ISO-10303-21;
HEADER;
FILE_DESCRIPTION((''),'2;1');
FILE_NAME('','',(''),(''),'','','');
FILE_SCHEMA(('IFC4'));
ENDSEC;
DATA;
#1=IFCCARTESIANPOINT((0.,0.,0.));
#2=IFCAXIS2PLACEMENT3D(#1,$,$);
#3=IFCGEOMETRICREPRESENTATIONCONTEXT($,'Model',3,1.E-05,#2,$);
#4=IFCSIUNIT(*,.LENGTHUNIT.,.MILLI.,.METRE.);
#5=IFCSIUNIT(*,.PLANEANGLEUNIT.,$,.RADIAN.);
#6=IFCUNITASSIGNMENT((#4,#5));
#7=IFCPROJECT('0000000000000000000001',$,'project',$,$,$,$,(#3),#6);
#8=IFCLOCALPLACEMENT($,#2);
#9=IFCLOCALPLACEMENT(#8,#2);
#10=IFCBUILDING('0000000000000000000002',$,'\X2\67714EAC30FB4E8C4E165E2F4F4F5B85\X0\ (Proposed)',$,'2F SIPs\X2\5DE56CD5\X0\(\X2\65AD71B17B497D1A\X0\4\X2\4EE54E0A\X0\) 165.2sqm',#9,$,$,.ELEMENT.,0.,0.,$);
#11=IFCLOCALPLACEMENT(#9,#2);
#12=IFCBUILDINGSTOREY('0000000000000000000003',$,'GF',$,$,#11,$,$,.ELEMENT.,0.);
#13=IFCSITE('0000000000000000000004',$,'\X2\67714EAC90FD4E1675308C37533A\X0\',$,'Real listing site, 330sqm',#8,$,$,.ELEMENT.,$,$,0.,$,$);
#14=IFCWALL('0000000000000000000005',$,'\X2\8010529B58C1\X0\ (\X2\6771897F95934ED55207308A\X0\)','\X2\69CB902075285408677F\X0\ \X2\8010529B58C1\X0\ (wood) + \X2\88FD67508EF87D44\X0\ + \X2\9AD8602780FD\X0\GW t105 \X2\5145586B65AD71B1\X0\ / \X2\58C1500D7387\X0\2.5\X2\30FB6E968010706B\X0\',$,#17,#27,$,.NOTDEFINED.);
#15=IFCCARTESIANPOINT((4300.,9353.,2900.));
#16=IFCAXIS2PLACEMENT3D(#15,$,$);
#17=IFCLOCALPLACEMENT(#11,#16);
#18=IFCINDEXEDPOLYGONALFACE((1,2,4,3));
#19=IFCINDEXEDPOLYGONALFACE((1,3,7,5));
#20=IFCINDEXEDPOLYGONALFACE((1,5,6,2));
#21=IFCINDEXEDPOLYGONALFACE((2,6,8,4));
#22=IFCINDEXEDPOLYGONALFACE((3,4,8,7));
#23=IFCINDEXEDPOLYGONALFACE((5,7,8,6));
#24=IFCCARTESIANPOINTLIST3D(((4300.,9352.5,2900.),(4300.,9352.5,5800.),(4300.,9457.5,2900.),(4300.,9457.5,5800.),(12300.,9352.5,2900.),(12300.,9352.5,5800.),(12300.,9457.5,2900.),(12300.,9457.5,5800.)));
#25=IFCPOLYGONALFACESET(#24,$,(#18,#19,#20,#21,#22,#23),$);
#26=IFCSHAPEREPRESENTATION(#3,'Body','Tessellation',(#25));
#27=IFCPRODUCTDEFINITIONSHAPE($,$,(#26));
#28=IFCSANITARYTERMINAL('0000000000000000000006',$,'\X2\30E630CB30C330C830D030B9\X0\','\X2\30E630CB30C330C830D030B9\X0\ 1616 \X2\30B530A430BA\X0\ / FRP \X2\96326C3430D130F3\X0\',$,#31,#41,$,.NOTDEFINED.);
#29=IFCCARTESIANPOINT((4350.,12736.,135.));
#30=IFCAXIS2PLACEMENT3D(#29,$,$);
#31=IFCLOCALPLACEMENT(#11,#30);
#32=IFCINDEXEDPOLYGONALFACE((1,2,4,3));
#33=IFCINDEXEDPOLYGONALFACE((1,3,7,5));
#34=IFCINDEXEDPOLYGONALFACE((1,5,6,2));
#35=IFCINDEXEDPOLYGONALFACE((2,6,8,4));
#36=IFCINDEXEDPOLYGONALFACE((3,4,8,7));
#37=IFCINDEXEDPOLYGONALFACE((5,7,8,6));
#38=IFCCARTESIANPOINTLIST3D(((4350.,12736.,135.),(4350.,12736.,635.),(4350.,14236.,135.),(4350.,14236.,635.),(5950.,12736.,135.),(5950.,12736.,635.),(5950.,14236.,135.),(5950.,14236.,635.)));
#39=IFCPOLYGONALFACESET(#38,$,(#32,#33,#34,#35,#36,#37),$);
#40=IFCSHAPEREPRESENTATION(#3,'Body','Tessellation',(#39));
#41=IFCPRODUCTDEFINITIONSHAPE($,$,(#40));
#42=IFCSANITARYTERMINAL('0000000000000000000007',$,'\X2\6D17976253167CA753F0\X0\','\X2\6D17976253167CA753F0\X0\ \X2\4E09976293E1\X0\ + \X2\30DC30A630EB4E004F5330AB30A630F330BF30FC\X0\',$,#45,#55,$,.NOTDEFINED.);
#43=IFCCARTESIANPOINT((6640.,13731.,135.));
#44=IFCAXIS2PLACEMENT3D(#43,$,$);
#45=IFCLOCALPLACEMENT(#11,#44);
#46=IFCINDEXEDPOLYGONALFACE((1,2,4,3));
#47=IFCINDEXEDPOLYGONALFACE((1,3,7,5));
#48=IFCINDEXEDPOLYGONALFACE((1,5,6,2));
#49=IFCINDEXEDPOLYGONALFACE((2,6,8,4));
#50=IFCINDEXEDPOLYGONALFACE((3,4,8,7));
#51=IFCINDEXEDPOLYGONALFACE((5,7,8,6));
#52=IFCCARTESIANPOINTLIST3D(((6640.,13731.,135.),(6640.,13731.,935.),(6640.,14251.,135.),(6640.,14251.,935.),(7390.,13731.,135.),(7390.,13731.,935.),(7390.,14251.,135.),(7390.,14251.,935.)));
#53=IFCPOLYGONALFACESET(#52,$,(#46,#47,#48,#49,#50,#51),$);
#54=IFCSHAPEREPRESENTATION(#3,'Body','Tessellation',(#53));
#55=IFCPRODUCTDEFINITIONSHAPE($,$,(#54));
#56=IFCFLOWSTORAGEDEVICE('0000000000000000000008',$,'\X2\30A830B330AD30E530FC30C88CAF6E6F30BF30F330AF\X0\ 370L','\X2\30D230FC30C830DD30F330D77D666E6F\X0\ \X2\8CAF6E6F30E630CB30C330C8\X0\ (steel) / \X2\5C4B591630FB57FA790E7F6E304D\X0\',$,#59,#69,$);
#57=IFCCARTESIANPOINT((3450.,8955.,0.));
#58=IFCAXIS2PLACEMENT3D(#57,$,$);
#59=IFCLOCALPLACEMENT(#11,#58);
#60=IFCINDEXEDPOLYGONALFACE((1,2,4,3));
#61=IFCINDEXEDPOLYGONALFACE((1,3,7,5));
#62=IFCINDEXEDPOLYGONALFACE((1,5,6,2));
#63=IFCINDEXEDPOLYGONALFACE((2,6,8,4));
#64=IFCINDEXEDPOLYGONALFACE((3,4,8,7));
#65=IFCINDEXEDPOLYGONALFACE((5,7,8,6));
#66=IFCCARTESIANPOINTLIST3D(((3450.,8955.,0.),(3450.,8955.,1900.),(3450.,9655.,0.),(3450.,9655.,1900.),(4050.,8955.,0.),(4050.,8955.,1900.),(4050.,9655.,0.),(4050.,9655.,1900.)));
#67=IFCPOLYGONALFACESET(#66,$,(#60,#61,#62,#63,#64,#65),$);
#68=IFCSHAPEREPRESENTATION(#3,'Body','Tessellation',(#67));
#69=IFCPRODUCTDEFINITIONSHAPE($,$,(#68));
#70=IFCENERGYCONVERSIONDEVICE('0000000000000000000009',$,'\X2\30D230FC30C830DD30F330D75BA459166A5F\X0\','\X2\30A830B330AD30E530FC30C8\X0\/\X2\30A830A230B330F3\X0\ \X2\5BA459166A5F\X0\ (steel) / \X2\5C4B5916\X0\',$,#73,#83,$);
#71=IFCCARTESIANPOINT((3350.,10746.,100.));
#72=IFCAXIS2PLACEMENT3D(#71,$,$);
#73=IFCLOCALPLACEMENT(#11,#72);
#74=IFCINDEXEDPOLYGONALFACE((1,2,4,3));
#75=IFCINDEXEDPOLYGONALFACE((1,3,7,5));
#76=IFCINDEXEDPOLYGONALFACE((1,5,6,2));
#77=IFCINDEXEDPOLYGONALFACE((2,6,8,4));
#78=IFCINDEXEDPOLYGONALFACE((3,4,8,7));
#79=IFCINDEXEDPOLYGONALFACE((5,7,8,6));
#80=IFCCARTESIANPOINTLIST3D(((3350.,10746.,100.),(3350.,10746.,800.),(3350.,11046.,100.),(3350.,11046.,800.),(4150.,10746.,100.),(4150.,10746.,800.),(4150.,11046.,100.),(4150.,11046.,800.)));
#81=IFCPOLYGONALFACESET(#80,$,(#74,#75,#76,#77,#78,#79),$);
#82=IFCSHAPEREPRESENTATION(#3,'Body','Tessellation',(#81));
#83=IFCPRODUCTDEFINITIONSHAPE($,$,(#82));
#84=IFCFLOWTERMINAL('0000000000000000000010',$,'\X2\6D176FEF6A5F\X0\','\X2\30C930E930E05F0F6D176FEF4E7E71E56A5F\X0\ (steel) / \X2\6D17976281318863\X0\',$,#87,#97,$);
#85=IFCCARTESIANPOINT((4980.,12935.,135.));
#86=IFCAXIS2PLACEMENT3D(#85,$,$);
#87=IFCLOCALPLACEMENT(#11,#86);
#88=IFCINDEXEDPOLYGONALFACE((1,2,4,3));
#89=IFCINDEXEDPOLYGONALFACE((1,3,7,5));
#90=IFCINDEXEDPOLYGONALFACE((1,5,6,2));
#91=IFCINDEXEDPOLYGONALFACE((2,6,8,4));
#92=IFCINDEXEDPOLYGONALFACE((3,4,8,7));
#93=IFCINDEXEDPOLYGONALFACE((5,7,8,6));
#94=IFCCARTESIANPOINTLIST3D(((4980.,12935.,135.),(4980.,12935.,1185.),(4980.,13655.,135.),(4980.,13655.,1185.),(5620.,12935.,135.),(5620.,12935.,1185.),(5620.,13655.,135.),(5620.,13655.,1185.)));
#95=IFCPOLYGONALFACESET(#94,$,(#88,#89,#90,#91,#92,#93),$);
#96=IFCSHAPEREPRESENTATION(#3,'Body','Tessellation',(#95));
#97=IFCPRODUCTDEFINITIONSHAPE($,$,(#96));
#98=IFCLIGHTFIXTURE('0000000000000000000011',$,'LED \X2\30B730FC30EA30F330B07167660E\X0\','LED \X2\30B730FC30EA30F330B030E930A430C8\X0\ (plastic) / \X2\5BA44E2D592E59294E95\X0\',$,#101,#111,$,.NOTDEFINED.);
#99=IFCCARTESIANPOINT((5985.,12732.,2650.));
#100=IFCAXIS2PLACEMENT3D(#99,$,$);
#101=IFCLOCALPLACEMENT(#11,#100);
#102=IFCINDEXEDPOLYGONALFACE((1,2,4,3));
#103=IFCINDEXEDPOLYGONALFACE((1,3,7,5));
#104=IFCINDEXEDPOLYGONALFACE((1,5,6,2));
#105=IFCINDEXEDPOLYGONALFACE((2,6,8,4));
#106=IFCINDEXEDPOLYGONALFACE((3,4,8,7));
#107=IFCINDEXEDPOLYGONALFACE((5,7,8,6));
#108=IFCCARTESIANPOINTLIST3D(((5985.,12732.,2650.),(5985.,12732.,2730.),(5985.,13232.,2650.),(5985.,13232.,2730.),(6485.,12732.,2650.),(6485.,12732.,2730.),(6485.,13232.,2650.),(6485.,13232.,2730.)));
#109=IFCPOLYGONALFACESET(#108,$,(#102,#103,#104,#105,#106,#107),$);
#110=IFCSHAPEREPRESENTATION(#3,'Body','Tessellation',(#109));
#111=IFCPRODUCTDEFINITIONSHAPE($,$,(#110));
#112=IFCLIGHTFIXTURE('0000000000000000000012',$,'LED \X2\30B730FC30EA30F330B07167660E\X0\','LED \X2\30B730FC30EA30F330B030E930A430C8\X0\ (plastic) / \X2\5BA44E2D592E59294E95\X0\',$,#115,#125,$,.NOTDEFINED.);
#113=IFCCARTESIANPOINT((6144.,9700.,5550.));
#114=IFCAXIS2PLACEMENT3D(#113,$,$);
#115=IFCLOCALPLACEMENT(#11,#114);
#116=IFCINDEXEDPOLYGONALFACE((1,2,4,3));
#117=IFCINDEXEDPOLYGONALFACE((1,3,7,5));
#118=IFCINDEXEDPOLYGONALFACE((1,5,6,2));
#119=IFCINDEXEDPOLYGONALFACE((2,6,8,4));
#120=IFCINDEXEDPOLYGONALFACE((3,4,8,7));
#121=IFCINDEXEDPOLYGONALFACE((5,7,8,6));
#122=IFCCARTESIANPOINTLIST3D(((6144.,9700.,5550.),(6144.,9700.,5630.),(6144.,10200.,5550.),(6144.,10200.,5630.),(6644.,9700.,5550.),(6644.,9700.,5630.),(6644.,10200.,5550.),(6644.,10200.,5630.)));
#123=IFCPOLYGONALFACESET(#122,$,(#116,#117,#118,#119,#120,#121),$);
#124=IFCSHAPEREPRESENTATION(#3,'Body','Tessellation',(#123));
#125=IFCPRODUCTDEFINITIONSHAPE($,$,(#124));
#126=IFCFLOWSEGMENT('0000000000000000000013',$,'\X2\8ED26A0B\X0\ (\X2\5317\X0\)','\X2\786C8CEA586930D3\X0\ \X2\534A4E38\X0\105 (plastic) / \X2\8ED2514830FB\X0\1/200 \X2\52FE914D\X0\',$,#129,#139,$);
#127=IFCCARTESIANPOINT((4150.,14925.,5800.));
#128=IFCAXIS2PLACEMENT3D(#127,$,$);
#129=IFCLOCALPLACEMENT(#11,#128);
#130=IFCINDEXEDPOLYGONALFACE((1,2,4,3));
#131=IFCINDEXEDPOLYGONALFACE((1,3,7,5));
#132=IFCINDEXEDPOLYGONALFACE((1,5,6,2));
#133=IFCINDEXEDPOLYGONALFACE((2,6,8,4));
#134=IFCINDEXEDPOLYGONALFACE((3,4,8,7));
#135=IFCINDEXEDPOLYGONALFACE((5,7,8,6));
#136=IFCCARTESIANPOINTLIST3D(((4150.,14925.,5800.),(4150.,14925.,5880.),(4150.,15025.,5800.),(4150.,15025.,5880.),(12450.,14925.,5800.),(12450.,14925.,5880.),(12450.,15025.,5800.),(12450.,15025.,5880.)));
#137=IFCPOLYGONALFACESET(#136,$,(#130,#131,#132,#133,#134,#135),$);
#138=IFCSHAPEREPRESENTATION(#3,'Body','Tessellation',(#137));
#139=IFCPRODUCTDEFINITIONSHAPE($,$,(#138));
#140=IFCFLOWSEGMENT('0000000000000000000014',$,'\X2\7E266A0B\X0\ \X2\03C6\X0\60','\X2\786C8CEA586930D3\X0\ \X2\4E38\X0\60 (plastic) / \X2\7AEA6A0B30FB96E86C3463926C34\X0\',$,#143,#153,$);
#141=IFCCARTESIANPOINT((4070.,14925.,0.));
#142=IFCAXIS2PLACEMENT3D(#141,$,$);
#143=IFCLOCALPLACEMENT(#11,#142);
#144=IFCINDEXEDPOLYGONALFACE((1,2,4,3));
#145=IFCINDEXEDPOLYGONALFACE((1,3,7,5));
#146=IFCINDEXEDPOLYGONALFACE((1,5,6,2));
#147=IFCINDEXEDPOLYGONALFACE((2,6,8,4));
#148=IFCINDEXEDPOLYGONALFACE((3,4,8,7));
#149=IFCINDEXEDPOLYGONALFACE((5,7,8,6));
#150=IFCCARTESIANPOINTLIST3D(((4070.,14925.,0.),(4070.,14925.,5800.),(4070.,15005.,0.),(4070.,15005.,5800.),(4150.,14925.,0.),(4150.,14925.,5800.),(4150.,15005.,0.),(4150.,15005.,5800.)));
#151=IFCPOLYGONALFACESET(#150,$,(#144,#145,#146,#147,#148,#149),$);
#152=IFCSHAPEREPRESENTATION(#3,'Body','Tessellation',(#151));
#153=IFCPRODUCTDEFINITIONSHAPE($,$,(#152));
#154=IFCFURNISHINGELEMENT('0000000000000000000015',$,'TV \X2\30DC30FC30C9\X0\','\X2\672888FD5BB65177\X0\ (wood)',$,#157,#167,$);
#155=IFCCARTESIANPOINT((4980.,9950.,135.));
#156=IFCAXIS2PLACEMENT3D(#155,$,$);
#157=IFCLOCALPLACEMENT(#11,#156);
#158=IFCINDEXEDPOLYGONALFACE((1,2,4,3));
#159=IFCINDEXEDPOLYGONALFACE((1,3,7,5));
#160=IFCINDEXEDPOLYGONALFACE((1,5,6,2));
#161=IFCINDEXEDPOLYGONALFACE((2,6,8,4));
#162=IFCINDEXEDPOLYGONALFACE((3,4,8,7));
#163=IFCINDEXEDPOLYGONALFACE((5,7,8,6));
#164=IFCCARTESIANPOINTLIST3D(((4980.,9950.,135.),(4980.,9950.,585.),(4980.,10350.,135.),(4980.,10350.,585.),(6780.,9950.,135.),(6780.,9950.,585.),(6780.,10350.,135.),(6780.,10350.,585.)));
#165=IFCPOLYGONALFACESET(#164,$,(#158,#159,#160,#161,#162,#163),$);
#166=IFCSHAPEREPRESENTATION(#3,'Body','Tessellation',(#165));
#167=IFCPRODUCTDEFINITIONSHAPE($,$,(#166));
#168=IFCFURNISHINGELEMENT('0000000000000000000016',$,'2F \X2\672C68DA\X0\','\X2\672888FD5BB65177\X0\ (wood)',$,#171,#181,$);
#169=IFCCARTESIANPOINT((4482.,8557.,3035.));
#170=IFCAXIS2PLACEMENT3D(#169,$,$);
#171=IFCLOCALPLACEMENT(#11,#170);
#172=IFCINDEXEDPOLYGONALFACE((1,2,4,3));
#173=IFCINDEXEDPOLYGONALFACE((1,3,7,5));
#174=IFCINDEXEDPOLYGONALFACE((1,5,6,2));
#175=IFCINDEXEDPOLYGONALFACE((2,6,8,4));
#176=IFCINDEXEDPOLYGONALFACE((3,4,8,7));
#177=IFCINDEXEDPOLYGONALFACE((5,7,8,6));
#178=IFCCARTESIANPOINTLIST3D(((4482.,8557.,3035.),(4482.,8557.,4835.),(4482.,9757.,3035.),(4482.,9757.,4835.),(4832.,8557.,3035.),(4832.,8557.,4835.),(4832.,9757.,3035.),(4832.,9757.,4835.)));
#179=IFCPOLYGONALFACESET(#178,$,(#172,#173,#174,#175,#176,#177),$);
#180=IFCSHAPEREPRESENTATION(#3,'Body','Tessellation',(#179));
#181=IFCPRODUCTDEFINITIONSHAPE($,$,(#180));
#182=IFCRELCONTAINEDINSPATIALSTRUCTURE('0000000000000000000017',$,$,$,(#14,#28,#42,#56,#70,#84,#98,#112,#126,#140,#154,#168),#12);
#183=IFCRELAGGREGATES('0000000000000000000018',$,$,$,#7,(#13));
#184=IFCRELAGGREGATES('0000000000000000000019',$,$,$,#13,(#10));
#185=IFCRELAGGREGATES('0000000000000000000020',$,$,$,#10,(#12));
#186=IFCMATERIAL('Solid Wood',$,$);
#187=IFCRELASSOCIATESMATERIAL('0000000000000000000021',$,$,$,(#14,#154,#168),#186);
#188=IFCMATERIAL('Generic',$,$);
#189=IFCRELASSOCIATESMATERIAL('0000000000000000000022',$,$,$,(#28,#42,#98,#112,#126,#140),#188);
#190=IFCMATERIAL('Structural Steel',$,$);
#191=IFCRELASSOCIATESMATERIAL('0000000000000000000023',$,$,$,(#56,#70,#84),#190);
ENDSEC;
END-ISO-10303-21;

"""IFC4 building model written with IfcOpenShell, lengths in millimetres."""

from ifc_helpers import new_model, si_unit, frame, frame_2d, origin, place, context, project, spatial, rectangle, extrude, material, element, save


model = new_model("IFC4")

# Units and contexts
model_context = context("Model", 3, precision=1e-05, world=origin())
ifc_project = project(units=[si_unit("LENGTHUNIT", "METRE", prefix="MILLI"), si_unit("PLANEANGLEUNIT", "RADIAN")], contexts=[model_context])

# Site, building, storey
site_placement = place(None, origin())
site = spatial("IfcSite", under=ifc_project, at=site_placement, Name="東京都世田谷区", ObjectType="Real listing site, 330sqm", CompositionType="ELEMENT", RefElevation=0.0)
building_placement = place(site_placement, origin())
building = spatial("IfcBuilding", under=site, at=building_placement, Name="東京・二世帯住宅 (Proposed)", ObjectType="2F SIPs工法(断熱等級4以上) 165.2sqm", CompositionType="ELEMENT", ElevationOfRefHeight=0.0, ElevationOfTerrain=0.0)
storey_placement = place(building_placement, origin())
storey = spatial("IfcBuildingStorey", under=building, at=storey_placement, Name="GF", CompositionType="ELEMENT", Elevation=0.0)

# Shared definitions
ifc_material_1 = material(Name="Solid Wood")

# Wall
wall_1_placement = place(storey_placement, frame((4300.0, 9353.0, 2900.0)))
element("IfcWall", 1, at=wall_1_placement, inside=storey, material=ifc_material_1, Name="耐力壁 (東西間仕切り)", Description="構造用合板 耐力壁 (wood) + 製材軸組 + 高性能GW t105 充填断熱 / 壁倍率2.5・準耐火", PredefinedType="NOTDEFINED", context=model_context, shape_type="SweptSolid", body=[
    extrude(rectangle(XDim=8000.0, YDim=105.0, at=frame_2d((4000.0, 52.0))), frame((4300.0, 9353.0, 2900.0)), (0.0, 0.0, 1.0), 2900.0),
])

# Sanitary terminals
ifc_material_2 = material(Name="Generic")
sanitary_terminal_1_placement = place(storey_placement, frame((4350.0, 12736.0, 135.0)))
element("IfcSanitaryTerminal", 2, at=sanitary_terminal_1_placement, inside=storey, material=ifc_material_2, Name="ユニットバス", Description="ユニットバス 1616 サイズ / FRP 防水パン", PredefinedType="NOTDEFINED", context=model_context, shape_type="SweptSolid", body=[
    extrude(rectangle(XDim=1600.0, YDim=1500.0, at=frame_2d((800.0, 750.0))), frame((4350.0, 12736.0, 135.0)), (0.0, 0.0, 1.0), 500.0),
])
sanitary_terminal_2_placement = place(storey_placement, frame((6640.0, 13731.0, 135.0)))
element("IfcSanitaryTerminal", 3, at=sanitary_terminal_2_placement, inside=storey, material=ifc_material_2, Name="洗面化粧台", Description="洗面化粧台 三面鏡 + ボウル一体カウンター", PredefinedType="NOTDEFINED", context=model_context, shape_type="SweptSolid", body=[
    extrude(rectangle(XDim=750.0, YDim=520.0, at=frame_2d((375.0, 260.0))), frame((6640.0, 13731.0, 135.0)), (0.0, 0.0, 1.0), 800.0),
])

# Flow storage device
ifc_material_3 = material(Name="Structural Steel")
flow_storage_device_placement = place(storey_placement, frame((3450.0, 8955.0, 0.0)))
element("IfcFlowStorageDevice", 4, at=flow_storage_device_placement, inside=storey, material=ifc_material_3, Name="エコキュート貯湯タンク 370L", Description="ヒートポンプ給湯 貯湯ユニット (steel) / 屋外・基礎置き", context=model_context, shape_type="SweptSolid", body=[
    extrude(rectangle(XDim=600.0, YDim=700.0, at=frame_2d((300.0, 350.0))), frame((3450.0, 8955.0, 0.0)), (0.0, 0.0, 1.0), 1900.0),
])

# Energy conversion device
energy_conversion_device_placement = place(storey_placement, frame((3350.0, 10746.0, 100.0)))
element("IfcEnergyConversionDevice", 5, at=energy_conversion_device_placement, inside=storey, material=ifc_material_3, Name="ヒートポンプ室外機", Description="エコキュート/エアコン 室外機 (steel) / 屋外", context=model_context, shape_type="SweptSolid", body=[
    extrude(rectangle(XDim=800.0, YDim=300.0, at=frame_2d((400.0, 150.0))), frame((3350.0, 10746.0, 100.0)), (0.0, 0.0, 1.0), 700.0),
])

# Flow terminal
flow_terminal_placement = place(storey_placement, frame((4980.0, 12935.0, 135.0)))
element("IfcFlowTerminal", 6, at=flow_terminal_placement, inside=storey, material=ifc_material_3, Name="洗濯機", Description="ドラム式洗濯乾燥機 (steel) / 洗面脱衣", context=model_context, shape_type="SweptSolid", body=[
    extrude(rectangle(XDim=640.0, YDim=720.0, at=frame_2d((320.0, 360.0))), frame((4980.0, 12935.0, 135.0)), (0.0, 0.0, 1.0), 1050.0),
])

# Light fixtures
light_fixture_1_placement = place(storey_placement, frame((5985.0, 12732.0, 2650.0)))
element("IfcLightFixture", 7, at=light_fixture_1_placement, inside=storey, material=ifc_material_2, Name="LED シーリング照明", Description="LED シーリングライト (plastic) / 室中央天井", PredefinedType="NOTDEFINED", context=model_context, shape_type="SweptSolid", body=[
    extrude(rectangle(XDim=500.0, YDim=500.0, at=frame_2d((250.0, 250.0))), frame((5985.0, 12732.0, 2650.0)), (0.0, 0.0, 1.0), 80.0),
])
light_fixture_2_placement = place(storey_placement, frame((6144.0, 9700.0, 5550.0)))
element("IfcLightFixture", 8, at=light_fixture_2_placement, inside=storey, material=ifc_material_2, Name="LED シーリング照明", Description="LED シーリングライト (plastic) / 室中央天井", PredefinedType="NOTDEFINED", context=model_context, shape_type="SweptSolid", body=[
    extrude(rectangle(XDim=500.0, YDim=500.0, at=frame_2d((250.0, 250.0))), frame((6144.0, 9700.0, 5550.0)), (0.0, 0.0, 1.0), 80.0),
])

# Flow segments
flow_segment_1_placement = place(storey_placement, frame((4150.0, 14925.0, 5800.0)))
element("IfcFlowSegment", 9, at=flow_segment_1_placement, inside=storey, material=ifc_material_2, Name="軒樋 (北)", Description="硬質塩ビ 半丸105 (plastic) / 軒先・1/200 勾配", context=model_context, shape_type="SweptSolid", body=[
    extrude(rectangle(XDim=8300.0, YDim=100.0, at=frame_2d((4150.0, 50.0))), frame((4150.0, 14925.0, 5800.0)), (0.0, 0.0, 1.0), 80.0),
])
flow_segment_2_placement = place(storey_placement, frame((4070.0, 14925.0, 0.0)))
element("IfcFlowSegment", 10, at=flow_segment_2_placement, inside=storey, material=ifc_material_2, Name="縦樋 φ60", Description="硬質塩ビ 丸60 (plastic) / 竪樋・雨水排水", context=model_context, shape_type="SweptSolid", body=[
    extrude(rectangle(XDim=80.0, YDim=80.0, at=frame_2d((40.0, 40.0))), frame((4070.0, 14925.0, 0.0)), (0.0, 0.0, 1.0), 5800.0),
])

# Furnishing elements
furnishing_1_placement = place(storey_placement, frame((4980.0, 9950.0, 135.0)))
element("IfcFurnishingElement", 11, at=furnishing_1_placement, inside=storey, material=ifc_material_1, Name="TV ボード", Description="木製家具 (wood)", context=model_context, shape_type="SweptSolid", body=[
    extrude(rectangle(XDim=1800.0, YDim=400.0, at=frame_2d((900.0, 200.0))), frame((4980.0, 9950.0, 135.0)), (0.0, 0.0, 1.0), 450.0),
])
furnishing_2_placement = place(storey_placement, frame((4482.0, 8557.0, 3035.0)))
element("IfcFurnishingElement", 12, at=furnishing_2_placement, inside=storey, material=ifc_material_1, Name="2F 本棚", Description="木製家具 (wood)", context=model_context, shape_type="SweptSolid", body=[
    extrude(rectangle(XDim=350.0, YDim=1200.0, at=frame_2d((175.0, 600.0))), frame((4482.0, 8557.0, 3035.0)), (0.0, 0.0, 1.0), 1800.0),
])

save(model, "model.ifc")
